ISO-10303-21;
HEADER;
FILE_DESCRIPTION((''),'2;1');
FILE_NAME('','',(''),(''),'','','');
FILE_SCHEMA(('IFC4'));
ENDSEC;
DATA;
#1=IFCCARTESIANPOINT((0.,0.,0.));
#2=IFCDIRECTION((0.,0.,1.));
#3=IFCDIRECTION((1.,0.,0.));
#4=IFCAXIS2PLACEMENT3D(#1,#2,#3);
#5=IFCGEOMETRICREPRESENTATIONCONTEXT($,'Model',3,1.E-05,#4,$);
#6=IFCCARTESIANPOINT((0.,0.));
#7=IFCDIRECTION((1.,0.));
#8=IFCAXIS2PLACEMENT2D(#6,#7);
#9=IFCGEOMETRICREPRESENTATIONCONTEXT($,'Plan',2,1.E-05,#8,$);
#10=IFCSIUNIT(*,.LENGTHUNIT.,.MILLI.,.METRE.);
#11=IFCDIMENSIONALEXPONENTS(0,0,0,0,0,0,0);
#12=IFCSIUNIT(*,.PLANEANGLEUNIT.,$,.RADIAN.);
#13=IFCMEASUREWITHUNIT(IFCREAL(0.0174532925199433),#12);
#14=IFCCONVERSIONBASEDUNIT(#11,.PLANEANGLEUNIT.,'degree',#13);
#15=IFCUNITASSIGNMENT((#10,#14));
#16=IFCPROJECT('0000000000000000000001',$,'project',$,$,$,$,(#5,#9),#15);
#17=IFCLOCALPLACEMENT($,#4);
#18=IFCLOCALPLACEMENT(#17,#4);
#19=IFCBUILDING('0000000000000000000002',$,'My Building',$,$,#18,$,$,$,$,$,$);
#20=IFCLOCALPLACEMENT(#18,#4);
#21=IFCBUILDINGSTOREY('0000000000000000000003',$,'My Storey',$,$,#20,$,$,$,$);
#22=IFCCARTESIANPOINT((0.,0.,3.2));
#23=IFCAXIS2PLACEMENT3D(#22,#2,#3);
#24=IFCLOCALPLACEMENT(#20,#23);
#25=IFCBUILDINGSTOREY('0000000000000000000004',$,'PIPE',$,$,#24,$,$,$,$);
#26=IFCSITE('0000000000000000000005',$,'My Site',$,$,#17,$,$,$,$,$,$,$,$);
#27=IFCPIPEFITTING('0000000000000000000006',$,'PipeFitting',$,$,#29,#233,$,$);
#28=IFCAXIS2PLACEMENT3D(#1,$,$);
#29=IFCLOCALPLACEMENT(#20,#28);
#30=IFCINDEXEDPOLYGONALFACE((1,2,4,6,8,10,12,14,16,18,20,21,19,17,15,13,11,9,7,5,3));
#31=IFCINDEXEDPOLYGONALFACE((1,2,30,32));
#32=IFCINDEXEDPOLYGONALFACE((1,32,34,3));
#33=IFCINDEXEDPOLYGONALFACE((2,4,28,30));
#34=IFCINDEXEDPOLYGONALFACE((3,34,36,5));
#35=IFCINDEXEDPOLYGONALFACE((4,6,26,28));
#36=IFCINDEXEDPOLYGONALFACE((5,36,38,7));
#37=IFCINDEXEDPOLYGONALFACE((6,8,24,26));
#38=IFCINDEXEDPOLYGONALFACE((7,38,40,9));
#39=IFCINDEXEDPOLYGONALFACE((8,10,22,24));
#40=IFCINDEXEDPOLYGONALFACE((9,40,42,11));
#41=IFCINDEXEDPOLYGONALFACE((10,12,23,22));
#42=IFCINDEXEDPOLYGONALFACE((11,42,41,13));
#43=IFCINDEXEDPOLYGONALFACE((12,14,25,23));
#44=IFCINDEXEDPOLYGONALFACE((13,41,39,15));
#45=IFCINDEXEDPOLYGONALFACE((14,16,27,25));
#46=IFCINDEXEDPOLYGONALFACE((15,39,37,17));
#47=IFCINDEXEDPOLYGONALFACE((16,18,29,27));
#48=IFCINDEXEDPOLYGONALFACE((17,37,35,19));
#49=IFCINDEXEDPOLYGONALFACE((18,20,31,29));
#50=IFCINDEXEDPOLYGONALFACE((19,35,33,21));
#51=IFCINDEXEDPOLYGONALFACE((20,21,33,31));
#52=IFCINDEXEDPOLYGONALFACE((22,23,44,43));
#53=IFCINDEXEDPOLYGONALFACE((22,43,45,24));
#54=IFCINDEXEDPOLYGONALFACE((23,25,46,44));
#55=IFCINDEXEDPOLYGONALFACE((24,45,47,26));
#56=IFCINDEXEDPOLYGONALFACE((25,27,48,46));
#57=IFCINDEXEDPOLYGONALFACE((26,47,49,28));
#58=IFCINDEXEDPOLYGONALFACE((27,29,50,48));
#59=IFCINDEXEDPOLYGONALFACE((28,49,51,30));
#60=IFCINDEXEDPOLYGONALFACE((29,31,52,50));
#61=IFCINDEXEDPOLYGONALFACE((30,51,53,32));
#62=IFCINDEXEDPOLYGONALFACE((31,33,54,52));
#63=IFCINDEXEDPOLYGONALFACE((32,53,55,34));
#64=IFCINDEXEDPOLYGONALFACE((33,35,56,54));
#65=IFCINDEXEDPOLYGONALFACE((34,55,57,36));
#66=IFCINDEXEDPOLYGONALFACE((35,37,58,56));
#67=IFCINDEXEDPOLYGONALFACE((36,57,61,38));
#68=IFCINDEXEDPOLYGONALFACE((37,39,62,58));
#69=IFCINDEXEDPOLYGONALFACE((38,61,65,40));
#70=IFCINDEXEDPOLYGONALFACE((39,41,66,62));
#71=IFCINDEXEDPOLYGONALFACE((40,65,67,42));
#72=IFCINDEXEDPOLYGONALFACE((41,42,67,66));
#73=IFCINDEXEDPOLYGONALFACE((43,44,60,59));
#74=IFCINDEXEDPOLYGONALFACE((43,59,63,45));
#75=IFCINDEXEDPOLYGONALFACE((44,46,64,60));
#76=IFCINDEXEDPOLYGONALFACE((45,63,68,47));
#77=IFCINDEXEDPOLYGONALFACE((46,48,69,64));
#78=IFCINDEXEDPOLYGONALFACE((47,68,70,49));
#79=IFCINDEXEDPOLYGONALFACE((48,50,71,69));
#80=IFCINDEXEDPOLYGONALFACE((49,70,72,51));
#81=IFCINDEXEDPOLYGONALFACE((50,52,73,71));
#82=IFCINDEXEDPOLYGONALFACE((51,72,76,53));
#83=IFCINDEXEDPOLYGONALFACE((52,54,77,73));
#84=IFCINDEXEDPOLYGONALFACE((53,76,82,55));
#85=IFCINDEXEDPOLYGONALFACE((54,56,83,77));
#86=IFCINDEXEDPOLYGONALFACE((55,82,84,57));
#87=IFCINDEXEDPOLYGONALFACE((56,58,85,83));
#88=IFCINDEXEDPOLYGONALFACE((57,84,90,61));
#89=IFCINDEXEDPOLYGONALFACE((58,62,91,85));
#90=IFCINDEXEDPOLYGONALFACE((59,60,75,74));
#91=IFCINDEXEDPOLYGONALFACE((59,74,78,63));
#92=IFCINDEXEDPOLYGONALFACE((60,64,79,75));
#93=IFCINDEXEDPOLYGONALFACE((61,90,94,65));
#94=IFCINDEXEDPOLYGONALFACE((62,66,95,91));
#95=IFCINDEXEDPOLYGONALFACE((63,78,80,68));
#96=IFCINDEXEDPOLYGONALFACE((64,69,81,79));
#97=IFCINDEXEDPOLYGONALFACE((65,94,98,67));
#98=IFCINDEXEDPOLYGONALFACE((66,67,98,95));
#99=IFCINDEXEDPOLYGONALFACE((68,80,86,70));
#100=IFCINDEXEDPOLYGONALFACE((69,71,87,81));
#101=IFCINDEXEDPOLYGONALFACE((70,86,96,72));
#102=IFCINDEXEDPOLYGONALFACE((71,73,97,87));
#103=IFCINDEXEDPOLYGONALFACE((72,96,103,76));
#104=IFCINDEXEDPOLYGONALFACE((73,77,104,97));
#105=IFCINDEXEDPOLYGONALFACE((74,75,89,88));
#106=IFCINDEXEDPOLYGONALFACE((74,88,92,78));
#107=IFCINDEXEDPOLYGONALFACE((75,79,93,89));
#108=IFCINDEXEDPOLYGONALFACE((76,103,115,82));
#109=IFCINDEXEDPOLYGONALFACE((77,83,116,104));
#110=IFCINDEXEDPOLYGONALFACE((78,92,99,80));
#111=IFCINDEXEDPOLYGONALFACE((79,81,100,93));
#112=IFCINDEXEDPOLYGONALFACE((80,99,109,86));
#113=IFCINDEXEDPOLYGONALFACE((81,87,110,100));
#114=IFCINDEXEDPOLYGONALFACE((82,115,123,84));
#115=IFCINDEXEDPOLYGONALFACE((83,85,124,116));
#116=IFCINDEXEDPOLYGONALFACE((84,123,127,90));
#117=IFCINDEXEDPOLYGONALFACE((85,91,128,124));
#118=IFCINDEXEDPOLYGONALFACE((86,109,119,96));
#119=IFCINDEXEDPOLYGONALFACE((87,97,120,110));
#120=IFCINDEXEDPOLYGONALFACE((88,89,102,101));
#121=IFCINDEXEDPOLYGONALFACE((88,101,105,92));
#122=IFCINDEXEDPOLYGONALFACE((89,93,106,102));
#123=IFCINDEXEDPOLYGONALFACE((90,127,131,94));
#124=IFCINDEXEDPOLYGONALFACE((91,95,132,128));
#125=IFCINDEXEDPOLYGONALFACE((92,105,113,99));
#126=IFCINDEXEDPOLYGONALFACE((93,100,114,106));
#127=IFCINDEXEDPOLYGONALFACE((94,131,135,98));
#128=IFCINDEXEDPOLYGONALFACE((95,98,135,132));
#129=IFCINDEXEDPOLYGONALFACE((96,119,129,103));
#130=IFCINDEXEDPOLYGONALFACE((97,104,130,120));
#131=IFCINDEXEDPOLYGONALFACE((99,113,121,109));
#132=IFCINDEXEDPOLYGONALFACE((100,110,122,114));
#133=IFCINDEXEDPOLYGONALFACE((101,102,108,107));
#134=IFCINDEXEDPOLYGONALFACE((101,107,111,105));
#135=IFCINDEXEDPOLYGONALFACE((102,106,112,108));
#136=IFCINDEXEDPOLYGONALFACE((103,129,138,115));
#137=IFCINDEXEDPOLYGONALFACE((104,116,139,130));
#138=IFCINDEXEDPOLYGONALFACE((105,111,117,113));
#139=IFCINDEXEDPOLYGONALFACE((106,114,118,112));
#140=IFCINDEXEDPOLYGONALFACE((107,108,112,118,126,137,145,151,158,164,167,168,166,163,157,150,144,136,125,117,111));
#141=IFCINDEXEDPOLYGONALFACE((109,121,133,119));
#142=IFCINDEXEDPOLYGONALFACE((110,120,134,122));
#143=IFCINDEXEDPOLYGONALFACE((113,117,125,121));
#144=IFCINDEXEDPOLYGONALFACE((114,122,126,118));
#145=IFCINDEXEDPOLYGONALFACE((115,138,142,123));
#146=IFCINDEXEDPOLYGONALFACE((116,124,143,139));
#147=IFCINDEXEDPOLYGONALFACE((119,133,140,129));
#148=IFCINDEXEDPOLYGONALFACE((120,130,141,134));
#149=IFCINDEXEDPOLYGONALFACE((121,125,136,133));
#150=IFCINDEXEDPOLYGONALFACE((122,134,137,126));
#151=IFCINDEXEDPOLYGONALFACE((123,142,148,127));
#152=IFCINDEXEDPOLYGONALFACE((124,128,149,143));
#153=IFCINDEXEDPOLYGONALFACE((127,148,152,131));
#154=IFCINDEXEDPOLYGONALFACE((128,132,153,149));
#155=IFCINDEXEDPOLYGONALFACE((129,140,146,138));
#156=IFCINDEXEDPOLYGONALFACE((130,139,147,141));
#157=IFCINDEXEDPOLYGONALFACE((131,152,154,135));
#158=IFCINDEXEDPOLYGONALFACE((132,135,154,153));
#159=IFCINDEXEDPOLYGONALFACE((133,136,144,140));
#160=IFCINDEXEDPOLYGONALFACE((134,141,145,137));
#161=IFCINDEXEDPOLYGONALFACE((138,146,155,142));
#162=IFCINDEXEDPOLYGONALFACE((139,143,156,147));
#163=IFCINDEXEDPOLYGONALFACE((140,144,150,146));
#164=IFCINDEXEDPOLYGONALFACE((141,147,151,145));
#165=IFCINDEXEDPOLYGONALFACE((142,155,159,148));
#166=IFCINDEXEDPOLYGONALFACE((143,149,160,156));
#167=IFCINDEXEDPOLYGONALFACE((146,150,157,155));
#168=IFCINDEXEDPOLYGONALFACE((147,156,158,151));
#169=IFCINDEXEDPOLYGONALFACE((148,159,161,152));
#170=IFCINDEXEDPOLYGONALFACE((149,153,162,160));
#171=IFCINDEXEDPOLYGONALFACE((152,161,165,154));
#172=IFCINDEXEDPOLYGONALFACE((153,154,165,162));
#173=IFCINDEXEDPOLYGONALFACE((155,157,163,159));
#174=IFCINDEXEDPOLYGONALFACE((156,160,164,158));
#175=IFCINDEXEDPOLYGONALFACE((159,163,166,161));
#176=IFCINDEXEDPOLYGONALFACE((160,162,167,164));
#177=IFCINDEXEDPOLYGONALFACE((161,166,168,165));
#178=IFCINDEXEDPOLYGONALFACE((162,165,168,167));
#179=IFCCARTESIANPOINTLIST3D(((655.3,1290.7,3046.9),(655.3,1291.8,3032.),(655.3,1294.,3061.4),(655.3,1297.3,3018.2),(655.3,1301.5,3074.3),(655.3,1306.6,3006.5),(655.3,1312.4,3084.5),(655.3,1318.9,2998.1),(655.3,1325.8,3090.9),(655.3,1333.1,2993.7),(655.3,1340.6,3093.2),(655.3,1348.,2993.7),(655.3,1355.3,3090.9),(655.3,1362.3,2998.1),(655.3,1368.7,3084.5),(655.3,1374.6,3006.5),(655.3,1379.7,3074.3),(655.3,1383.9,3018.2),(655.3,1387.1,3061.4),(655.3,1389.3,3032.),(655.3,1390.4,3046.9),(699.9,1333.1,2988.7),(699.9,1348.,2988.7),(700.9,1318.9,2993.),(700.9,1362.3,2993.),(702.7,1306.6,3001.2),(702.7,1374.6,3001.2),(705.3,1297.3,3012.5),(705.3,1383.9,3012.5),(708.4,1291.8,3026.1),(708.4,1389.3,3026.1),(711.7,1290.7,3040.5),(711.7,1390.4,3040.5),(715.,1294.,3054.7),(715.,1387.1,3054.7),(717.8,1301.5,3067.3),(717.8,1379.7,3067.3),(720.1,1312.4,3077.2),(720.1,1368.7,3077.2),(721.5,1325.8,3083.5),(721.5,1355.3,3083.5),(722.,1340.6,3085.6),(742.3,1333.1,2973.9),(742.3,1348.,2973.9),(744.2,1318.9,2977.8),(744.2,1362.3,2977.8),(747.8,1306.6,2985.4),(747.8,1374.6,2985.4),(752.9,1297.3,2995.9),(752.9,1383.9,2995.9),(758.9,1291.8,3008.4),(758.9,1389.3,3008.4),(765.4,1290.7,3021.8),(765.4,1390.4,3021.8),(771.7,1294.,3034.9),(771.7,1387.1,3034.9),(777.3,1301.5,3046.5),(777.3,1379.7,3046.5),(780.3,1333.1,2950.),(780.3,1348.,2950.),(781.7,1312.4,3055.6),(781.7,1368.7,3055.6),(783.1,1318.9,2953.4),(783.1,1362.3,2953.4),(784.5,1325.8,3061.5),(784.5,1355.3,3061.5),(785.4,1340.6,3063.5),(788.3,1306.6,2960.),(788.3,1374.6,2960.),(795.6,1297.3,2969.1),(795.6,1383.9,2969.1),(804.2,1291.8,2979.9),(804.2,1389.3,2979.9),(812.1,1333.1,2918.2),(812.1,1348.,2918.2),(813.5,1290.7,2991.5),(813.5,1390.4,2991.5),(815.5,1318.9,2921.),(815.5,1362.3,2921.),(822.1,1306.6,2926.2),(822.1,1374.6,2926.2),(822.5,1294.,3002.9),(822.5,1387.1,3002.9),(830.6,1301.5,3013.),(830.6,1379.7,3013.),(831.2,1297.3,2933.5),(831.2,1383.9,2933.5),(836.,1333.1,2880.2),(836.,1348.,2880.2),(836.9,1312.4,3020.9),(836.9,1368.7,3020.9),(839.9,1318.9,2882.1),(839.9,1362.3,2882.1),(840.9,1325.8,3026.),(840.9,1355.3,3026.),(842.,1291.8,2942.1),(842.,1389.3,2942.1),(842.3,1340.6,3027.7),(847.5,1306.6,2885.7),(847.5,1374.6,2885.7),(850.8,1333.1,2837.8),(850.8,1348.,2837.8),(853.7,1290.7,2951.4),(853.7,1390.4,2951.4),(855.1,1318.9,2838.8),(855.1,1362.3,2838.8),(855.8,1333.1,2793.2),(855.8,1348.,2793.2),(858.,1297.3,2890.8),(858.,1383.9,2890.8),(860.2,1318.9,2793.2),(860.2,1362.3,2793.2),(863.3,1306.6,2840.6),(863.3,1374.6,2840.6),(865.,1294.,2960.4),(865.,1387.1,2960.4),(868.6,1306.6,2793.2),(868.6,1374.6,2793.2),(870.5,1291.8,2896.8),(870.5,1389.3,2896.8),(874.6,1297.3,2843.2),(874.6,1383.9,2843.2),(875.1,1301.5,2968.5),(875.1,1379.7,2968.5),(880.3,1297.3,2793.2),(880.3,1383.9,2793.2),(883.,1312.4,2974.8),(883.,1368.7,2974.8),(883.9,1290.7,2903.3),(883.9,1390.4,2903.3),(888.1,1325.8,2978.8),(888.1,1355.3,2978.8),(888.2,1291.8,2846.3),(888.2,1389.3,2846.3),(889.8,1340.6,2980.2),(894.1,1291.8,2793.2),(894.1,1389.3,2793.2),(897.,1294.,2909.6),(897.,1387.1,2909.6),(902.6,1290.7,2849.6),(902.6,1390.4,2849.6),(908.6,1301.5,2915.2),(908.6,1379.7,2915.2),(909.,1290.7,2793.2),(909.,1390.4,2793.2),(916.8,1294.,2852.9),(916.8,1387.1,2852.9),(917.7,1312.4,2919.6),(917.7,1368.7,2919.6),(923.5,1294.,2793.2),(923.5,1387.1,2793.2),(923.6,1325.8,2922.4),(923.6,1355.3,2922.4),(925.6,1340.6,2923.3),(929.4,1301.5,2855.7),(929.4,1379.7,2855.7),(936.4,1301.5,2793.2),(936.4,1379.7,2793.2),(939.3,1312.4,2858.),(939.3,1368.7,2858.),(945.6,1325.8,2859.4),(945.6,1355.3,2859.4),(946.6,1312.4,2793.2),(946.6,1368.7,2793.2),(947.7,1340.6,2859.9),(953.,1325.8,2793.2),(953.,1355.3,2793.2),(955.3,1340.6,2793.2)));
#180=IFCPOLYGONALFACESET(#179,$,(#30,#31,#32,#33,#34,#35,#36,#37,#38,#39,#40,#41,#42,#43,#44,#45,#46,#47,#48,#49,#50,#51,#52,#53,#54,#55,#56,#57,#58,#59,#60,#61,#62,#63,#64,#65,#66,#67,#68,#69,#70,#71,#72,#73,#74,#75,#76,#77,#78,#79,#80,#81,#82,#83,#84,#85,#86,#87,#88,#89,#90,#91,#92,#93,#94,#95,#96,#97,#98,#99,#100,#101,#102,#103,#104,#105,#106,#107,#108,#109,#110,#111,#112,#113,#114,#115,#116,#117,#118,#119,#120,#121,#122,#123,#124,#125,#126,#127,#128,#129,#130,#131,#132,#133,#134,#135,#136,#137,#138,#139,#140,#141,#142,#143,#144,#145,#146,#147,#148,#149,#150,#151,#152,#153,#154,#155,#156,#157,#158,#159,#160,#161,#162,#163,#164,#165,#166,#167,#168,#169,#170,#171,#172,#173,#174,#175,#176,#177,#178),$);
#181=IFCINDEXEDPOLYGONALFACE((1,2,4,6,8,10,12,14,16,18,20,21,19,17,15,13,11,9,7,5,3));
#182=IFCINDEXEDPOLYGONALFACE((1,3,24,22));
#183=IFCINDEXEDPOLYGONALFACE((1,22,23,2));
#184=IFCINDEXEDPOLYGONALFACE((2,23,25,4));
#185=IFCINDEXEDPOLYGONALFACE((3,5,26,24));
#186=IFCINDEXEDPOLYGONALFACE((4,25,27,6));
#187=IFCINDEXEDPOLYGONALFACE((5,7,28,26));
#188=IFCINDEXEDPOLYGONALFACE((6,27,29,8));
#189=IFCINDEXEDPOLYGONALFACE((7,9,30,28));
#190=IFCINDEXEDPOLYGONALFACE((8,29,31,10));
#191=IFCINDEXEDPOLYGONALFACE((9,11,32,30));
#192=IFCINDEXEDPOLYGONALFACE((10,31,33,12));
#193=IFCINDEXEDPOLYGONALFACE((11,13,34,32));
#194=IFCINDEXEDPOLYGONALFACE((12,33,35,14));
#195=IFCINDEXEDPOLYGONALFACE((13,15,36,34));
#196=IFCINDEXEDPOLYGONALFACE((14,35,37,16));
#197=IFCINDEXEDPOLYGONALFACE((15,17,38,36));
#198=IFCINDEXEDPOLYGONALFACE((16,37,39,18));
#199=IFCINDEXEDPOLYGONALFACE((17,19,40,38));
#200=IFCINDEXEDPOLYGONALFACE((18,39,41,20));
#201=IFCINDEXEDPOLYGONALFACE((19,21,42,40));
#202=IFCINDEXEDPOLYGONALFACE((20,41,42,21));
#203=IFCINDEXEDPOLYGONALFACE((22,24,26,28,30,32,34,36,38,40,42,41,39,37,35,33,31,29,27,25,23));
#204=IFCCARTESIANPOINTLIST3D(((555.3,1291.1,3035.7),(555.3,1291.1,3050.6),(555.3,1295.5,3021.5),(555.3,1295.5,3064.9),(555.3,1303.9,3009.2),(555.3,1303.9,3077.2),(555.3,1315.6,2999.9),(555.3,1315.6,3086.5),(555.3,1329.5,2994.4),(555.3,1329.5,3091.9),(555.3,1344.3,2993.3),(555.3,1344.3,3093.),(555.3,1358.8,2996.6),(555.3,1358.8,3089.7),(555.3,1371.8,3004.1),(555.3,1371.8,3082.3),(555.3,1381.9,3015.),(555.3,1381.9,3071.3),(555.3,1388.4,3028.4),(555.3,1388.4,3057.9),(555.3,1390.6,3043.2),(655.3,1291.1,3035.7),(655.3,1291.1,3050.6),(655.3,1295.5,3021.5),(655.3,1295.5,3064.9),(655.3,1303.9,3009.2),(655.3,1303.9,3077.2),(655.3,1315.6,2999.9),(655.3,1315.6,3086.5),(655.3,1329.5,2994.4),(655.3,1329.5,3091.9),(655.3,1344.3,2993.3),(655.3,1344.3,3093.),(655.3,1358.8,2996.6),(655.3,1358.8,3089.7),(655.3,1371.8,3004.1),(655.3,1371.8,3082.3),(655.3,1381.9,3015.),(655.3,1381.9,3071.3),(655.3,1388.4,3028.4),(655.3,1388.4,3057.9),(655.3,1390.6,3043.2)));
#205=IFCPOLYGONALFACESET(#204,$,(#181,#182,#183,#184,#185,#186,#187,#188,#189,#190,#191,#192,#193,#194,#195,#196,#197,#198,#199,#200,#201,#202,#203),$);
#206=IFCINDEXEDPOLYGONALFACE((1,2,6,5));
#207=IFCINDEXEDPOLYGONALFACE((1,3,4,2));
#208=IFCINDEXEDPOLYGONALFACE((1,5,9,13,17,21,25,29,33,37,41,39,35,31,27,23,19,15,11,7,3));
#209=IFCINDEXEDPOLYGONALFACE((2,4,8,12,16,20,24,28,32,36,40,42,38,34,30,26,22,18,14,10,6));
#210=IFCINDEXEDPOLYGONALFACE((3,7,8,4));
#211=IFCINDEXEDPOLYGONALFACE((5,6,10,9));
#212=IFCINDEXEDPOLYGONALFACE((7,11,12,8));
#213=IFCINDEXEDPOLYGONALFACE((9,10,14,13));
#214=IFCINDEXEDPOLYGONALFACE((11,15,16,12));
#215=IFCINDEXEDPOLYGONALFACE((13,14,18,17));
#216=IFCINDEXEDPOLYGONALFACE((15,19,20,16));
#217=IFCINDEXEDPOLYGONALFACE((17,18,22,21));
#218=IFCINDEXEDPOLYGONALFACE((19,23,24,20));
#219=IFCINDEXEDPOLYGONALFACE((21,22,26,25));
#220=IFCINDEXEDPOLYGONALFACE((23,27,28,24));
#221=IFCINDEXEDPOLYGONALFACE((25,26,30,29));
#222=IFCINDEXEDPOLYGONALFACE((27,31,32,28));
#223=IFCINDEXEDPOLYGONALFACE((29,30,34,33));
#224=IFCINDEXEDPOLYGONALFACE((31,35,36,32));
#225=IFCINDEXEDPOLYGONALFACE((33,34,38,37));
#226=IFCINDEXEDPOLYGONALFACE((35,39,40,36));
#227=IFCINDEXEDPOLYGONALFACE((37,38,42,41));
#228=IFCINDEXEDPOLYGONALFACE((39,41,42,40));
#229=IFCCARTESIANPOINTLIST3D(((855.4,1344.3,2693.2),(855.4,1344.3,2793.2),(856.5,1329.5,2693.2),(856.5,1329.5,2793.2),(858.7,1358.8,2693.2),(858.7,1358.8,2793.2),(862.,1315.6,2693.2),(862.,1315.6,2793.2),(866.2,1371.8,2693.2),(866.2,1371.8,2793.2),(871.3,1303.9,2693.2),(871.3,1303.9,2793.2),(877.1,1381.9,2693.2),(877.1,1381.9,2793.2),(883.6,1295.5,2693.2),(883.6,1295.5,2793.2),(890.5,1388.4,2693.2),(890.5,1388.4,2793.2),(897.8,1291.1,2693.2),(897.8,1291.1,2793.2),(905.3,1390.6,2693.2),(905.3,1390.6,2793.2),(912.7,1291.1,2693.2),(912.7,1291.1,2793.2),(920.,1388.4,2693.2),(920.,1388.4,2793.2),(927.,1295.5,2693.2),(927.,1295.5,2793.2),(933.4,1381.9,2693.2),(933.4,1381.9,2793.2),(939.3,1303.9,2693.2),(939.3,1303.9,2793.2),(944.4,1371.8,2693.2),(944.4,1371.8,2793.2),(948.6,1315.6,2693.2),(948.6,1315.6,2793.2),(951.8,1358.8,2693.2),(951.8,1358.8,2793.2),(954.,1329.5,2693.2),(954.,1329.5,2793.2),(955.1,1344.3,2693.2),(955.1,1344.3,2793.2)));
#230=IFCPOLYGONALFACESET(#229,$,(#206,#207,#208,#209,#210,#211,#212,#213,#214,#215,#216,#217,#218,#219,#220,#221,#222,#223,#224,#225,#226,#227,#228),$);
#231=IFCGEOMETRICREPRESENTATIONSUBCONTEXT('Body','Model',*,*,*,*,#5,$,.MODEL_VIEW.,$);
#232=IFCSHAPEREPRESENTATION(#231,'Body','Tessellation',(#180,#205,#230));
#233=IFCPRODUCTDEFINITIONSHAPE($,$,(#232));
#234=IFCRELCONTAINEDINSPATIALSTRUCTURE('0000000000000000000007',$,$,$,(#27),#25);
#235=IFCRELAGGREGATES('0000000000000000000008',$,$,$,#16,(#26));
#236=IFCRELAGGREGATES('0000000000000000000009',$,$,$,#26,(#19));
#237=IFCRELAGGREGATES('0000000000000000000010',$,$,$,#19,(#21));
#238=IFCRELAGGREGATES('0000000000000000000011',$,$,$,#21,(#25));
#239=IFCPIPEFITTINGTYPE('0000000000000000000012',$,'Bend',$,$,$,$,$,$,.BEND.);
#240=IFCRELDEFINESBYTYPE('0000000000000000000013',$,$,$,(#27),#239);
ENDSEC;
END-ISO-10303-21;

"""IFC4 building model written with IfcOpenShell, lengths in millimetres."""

from ifc_helpers import new_model, entity, si_unit, converted_unit, frame, origin_with_axes, origin_2d_with_axis, place, context, subcontext, project, spatial, circle, extrude, source, transform, mapped, type_object, type_shapes, element, save


model = new_model("IFC4")

# Units and contexts
model_context = context("Model", 3, precision=1e-05, world=origin_with_axes())
plan_context = context("Plan", 2, precision=1e-05, world=origin_2d_with_axis())
body_context = subcontext(model_context, "Body", "Model", "MODEL_VIEW")
ifc_project = project(units=[si_unit("LENGTHUNIT", "METRE", prefix="MILLI"), converted_unit("PLANEANGLEUNIT", "degree", entity("IfcReal", 0.0174532925199433), si_unit("PLANEANGLEUNIT", "RADIAN"), dimensions=[0, 0, 0, 0, 0, 0, 0])], contexts=[model_context, plan_context])

# Site, building, storeys
site_placement = place(None, origin_with_axes())
site = spatial("IfcSite", under=ifc_project, at=site_placement, Name="My Site")
building_placement = place(site_placement, origin_with_axes())
building = spatial("IfcBuilding", under=site, at=building_placement, Name="My Building")
storey_1_placement = place(building_placement, origin_with_axes())
storey_1 = spatial("IfcBuildingStorey", under=building, at=storey_1_placement, Name="My Storey")
storey_2_placement = place(storey_1_placement, frame((0.0, 0.0, 3.2), z_axis=(0.0, 0.0, 1.0), x_axis=(1.0, 0.0, 0.0)))
storey_2 = spatial("IfcBuildingStorey", under=storey_1, at=storey_2_placement, Name="PIPE")

# Pipe fitting
pipe_fitting_type = type_object("IfcPipeFittingType", Name="Bend", PredefinedType="BEND")
shared_shape = source(origin_with_axes(), body_context, "Body", "SolidModel", [
    entity("IfcSweptDiskSolid", entity("IfcIndexedPolyCurve", entity("IfcCartesianPointList3D", [[0.0, 0.0, 100.0], [0.0, -73.2, 276.8], [0.0, -250.0, 350.0]]), [entity("IfcArcIndex", [1, 2, 3])]), 50.0),
    extrude(circle(Radius=50.0), origin_with_axes(), (0.0, 0.0, 1.0), 100.0),
    extrude(circle(Radius=50.0), frame((0.0, -250.0, 350.0), z_axis=(0.0, -1.0, 0.0), x_axis=(1.0, 0.0, 0.0)), (0.0, 0.0, 1.0), 100.0),
])
type_shapes(pipe_fitting_type, [shared_shape])
for number, where, z_axis, x_axis, name in (
    (1, (555.3, 1340.6, 3040.0), (1.0, 0.0, 0.0), (0.0, 1.0, 0.0), "PipeFitting"),
):
    element("IfcPipeFitting", number, at=place(storey_2_placement, frame(where, z_axis=z_axis, x_axis=x_axis)), inside=storey_2, type_object=pipe_fitting_type, Name=name, context=body_context, shape_type="MappedRepresentation", body=[
        mapped(shared_shape, transform((0.0, 0.0, 0.0), x_axis=(1.0, 0.0, 0.0), y_axis=(0.0, 1.0, 0.0), z_axis=(0.0, 0.0, 1.0), scale=1.0)),
    ])

save(model, "model.ifc")
